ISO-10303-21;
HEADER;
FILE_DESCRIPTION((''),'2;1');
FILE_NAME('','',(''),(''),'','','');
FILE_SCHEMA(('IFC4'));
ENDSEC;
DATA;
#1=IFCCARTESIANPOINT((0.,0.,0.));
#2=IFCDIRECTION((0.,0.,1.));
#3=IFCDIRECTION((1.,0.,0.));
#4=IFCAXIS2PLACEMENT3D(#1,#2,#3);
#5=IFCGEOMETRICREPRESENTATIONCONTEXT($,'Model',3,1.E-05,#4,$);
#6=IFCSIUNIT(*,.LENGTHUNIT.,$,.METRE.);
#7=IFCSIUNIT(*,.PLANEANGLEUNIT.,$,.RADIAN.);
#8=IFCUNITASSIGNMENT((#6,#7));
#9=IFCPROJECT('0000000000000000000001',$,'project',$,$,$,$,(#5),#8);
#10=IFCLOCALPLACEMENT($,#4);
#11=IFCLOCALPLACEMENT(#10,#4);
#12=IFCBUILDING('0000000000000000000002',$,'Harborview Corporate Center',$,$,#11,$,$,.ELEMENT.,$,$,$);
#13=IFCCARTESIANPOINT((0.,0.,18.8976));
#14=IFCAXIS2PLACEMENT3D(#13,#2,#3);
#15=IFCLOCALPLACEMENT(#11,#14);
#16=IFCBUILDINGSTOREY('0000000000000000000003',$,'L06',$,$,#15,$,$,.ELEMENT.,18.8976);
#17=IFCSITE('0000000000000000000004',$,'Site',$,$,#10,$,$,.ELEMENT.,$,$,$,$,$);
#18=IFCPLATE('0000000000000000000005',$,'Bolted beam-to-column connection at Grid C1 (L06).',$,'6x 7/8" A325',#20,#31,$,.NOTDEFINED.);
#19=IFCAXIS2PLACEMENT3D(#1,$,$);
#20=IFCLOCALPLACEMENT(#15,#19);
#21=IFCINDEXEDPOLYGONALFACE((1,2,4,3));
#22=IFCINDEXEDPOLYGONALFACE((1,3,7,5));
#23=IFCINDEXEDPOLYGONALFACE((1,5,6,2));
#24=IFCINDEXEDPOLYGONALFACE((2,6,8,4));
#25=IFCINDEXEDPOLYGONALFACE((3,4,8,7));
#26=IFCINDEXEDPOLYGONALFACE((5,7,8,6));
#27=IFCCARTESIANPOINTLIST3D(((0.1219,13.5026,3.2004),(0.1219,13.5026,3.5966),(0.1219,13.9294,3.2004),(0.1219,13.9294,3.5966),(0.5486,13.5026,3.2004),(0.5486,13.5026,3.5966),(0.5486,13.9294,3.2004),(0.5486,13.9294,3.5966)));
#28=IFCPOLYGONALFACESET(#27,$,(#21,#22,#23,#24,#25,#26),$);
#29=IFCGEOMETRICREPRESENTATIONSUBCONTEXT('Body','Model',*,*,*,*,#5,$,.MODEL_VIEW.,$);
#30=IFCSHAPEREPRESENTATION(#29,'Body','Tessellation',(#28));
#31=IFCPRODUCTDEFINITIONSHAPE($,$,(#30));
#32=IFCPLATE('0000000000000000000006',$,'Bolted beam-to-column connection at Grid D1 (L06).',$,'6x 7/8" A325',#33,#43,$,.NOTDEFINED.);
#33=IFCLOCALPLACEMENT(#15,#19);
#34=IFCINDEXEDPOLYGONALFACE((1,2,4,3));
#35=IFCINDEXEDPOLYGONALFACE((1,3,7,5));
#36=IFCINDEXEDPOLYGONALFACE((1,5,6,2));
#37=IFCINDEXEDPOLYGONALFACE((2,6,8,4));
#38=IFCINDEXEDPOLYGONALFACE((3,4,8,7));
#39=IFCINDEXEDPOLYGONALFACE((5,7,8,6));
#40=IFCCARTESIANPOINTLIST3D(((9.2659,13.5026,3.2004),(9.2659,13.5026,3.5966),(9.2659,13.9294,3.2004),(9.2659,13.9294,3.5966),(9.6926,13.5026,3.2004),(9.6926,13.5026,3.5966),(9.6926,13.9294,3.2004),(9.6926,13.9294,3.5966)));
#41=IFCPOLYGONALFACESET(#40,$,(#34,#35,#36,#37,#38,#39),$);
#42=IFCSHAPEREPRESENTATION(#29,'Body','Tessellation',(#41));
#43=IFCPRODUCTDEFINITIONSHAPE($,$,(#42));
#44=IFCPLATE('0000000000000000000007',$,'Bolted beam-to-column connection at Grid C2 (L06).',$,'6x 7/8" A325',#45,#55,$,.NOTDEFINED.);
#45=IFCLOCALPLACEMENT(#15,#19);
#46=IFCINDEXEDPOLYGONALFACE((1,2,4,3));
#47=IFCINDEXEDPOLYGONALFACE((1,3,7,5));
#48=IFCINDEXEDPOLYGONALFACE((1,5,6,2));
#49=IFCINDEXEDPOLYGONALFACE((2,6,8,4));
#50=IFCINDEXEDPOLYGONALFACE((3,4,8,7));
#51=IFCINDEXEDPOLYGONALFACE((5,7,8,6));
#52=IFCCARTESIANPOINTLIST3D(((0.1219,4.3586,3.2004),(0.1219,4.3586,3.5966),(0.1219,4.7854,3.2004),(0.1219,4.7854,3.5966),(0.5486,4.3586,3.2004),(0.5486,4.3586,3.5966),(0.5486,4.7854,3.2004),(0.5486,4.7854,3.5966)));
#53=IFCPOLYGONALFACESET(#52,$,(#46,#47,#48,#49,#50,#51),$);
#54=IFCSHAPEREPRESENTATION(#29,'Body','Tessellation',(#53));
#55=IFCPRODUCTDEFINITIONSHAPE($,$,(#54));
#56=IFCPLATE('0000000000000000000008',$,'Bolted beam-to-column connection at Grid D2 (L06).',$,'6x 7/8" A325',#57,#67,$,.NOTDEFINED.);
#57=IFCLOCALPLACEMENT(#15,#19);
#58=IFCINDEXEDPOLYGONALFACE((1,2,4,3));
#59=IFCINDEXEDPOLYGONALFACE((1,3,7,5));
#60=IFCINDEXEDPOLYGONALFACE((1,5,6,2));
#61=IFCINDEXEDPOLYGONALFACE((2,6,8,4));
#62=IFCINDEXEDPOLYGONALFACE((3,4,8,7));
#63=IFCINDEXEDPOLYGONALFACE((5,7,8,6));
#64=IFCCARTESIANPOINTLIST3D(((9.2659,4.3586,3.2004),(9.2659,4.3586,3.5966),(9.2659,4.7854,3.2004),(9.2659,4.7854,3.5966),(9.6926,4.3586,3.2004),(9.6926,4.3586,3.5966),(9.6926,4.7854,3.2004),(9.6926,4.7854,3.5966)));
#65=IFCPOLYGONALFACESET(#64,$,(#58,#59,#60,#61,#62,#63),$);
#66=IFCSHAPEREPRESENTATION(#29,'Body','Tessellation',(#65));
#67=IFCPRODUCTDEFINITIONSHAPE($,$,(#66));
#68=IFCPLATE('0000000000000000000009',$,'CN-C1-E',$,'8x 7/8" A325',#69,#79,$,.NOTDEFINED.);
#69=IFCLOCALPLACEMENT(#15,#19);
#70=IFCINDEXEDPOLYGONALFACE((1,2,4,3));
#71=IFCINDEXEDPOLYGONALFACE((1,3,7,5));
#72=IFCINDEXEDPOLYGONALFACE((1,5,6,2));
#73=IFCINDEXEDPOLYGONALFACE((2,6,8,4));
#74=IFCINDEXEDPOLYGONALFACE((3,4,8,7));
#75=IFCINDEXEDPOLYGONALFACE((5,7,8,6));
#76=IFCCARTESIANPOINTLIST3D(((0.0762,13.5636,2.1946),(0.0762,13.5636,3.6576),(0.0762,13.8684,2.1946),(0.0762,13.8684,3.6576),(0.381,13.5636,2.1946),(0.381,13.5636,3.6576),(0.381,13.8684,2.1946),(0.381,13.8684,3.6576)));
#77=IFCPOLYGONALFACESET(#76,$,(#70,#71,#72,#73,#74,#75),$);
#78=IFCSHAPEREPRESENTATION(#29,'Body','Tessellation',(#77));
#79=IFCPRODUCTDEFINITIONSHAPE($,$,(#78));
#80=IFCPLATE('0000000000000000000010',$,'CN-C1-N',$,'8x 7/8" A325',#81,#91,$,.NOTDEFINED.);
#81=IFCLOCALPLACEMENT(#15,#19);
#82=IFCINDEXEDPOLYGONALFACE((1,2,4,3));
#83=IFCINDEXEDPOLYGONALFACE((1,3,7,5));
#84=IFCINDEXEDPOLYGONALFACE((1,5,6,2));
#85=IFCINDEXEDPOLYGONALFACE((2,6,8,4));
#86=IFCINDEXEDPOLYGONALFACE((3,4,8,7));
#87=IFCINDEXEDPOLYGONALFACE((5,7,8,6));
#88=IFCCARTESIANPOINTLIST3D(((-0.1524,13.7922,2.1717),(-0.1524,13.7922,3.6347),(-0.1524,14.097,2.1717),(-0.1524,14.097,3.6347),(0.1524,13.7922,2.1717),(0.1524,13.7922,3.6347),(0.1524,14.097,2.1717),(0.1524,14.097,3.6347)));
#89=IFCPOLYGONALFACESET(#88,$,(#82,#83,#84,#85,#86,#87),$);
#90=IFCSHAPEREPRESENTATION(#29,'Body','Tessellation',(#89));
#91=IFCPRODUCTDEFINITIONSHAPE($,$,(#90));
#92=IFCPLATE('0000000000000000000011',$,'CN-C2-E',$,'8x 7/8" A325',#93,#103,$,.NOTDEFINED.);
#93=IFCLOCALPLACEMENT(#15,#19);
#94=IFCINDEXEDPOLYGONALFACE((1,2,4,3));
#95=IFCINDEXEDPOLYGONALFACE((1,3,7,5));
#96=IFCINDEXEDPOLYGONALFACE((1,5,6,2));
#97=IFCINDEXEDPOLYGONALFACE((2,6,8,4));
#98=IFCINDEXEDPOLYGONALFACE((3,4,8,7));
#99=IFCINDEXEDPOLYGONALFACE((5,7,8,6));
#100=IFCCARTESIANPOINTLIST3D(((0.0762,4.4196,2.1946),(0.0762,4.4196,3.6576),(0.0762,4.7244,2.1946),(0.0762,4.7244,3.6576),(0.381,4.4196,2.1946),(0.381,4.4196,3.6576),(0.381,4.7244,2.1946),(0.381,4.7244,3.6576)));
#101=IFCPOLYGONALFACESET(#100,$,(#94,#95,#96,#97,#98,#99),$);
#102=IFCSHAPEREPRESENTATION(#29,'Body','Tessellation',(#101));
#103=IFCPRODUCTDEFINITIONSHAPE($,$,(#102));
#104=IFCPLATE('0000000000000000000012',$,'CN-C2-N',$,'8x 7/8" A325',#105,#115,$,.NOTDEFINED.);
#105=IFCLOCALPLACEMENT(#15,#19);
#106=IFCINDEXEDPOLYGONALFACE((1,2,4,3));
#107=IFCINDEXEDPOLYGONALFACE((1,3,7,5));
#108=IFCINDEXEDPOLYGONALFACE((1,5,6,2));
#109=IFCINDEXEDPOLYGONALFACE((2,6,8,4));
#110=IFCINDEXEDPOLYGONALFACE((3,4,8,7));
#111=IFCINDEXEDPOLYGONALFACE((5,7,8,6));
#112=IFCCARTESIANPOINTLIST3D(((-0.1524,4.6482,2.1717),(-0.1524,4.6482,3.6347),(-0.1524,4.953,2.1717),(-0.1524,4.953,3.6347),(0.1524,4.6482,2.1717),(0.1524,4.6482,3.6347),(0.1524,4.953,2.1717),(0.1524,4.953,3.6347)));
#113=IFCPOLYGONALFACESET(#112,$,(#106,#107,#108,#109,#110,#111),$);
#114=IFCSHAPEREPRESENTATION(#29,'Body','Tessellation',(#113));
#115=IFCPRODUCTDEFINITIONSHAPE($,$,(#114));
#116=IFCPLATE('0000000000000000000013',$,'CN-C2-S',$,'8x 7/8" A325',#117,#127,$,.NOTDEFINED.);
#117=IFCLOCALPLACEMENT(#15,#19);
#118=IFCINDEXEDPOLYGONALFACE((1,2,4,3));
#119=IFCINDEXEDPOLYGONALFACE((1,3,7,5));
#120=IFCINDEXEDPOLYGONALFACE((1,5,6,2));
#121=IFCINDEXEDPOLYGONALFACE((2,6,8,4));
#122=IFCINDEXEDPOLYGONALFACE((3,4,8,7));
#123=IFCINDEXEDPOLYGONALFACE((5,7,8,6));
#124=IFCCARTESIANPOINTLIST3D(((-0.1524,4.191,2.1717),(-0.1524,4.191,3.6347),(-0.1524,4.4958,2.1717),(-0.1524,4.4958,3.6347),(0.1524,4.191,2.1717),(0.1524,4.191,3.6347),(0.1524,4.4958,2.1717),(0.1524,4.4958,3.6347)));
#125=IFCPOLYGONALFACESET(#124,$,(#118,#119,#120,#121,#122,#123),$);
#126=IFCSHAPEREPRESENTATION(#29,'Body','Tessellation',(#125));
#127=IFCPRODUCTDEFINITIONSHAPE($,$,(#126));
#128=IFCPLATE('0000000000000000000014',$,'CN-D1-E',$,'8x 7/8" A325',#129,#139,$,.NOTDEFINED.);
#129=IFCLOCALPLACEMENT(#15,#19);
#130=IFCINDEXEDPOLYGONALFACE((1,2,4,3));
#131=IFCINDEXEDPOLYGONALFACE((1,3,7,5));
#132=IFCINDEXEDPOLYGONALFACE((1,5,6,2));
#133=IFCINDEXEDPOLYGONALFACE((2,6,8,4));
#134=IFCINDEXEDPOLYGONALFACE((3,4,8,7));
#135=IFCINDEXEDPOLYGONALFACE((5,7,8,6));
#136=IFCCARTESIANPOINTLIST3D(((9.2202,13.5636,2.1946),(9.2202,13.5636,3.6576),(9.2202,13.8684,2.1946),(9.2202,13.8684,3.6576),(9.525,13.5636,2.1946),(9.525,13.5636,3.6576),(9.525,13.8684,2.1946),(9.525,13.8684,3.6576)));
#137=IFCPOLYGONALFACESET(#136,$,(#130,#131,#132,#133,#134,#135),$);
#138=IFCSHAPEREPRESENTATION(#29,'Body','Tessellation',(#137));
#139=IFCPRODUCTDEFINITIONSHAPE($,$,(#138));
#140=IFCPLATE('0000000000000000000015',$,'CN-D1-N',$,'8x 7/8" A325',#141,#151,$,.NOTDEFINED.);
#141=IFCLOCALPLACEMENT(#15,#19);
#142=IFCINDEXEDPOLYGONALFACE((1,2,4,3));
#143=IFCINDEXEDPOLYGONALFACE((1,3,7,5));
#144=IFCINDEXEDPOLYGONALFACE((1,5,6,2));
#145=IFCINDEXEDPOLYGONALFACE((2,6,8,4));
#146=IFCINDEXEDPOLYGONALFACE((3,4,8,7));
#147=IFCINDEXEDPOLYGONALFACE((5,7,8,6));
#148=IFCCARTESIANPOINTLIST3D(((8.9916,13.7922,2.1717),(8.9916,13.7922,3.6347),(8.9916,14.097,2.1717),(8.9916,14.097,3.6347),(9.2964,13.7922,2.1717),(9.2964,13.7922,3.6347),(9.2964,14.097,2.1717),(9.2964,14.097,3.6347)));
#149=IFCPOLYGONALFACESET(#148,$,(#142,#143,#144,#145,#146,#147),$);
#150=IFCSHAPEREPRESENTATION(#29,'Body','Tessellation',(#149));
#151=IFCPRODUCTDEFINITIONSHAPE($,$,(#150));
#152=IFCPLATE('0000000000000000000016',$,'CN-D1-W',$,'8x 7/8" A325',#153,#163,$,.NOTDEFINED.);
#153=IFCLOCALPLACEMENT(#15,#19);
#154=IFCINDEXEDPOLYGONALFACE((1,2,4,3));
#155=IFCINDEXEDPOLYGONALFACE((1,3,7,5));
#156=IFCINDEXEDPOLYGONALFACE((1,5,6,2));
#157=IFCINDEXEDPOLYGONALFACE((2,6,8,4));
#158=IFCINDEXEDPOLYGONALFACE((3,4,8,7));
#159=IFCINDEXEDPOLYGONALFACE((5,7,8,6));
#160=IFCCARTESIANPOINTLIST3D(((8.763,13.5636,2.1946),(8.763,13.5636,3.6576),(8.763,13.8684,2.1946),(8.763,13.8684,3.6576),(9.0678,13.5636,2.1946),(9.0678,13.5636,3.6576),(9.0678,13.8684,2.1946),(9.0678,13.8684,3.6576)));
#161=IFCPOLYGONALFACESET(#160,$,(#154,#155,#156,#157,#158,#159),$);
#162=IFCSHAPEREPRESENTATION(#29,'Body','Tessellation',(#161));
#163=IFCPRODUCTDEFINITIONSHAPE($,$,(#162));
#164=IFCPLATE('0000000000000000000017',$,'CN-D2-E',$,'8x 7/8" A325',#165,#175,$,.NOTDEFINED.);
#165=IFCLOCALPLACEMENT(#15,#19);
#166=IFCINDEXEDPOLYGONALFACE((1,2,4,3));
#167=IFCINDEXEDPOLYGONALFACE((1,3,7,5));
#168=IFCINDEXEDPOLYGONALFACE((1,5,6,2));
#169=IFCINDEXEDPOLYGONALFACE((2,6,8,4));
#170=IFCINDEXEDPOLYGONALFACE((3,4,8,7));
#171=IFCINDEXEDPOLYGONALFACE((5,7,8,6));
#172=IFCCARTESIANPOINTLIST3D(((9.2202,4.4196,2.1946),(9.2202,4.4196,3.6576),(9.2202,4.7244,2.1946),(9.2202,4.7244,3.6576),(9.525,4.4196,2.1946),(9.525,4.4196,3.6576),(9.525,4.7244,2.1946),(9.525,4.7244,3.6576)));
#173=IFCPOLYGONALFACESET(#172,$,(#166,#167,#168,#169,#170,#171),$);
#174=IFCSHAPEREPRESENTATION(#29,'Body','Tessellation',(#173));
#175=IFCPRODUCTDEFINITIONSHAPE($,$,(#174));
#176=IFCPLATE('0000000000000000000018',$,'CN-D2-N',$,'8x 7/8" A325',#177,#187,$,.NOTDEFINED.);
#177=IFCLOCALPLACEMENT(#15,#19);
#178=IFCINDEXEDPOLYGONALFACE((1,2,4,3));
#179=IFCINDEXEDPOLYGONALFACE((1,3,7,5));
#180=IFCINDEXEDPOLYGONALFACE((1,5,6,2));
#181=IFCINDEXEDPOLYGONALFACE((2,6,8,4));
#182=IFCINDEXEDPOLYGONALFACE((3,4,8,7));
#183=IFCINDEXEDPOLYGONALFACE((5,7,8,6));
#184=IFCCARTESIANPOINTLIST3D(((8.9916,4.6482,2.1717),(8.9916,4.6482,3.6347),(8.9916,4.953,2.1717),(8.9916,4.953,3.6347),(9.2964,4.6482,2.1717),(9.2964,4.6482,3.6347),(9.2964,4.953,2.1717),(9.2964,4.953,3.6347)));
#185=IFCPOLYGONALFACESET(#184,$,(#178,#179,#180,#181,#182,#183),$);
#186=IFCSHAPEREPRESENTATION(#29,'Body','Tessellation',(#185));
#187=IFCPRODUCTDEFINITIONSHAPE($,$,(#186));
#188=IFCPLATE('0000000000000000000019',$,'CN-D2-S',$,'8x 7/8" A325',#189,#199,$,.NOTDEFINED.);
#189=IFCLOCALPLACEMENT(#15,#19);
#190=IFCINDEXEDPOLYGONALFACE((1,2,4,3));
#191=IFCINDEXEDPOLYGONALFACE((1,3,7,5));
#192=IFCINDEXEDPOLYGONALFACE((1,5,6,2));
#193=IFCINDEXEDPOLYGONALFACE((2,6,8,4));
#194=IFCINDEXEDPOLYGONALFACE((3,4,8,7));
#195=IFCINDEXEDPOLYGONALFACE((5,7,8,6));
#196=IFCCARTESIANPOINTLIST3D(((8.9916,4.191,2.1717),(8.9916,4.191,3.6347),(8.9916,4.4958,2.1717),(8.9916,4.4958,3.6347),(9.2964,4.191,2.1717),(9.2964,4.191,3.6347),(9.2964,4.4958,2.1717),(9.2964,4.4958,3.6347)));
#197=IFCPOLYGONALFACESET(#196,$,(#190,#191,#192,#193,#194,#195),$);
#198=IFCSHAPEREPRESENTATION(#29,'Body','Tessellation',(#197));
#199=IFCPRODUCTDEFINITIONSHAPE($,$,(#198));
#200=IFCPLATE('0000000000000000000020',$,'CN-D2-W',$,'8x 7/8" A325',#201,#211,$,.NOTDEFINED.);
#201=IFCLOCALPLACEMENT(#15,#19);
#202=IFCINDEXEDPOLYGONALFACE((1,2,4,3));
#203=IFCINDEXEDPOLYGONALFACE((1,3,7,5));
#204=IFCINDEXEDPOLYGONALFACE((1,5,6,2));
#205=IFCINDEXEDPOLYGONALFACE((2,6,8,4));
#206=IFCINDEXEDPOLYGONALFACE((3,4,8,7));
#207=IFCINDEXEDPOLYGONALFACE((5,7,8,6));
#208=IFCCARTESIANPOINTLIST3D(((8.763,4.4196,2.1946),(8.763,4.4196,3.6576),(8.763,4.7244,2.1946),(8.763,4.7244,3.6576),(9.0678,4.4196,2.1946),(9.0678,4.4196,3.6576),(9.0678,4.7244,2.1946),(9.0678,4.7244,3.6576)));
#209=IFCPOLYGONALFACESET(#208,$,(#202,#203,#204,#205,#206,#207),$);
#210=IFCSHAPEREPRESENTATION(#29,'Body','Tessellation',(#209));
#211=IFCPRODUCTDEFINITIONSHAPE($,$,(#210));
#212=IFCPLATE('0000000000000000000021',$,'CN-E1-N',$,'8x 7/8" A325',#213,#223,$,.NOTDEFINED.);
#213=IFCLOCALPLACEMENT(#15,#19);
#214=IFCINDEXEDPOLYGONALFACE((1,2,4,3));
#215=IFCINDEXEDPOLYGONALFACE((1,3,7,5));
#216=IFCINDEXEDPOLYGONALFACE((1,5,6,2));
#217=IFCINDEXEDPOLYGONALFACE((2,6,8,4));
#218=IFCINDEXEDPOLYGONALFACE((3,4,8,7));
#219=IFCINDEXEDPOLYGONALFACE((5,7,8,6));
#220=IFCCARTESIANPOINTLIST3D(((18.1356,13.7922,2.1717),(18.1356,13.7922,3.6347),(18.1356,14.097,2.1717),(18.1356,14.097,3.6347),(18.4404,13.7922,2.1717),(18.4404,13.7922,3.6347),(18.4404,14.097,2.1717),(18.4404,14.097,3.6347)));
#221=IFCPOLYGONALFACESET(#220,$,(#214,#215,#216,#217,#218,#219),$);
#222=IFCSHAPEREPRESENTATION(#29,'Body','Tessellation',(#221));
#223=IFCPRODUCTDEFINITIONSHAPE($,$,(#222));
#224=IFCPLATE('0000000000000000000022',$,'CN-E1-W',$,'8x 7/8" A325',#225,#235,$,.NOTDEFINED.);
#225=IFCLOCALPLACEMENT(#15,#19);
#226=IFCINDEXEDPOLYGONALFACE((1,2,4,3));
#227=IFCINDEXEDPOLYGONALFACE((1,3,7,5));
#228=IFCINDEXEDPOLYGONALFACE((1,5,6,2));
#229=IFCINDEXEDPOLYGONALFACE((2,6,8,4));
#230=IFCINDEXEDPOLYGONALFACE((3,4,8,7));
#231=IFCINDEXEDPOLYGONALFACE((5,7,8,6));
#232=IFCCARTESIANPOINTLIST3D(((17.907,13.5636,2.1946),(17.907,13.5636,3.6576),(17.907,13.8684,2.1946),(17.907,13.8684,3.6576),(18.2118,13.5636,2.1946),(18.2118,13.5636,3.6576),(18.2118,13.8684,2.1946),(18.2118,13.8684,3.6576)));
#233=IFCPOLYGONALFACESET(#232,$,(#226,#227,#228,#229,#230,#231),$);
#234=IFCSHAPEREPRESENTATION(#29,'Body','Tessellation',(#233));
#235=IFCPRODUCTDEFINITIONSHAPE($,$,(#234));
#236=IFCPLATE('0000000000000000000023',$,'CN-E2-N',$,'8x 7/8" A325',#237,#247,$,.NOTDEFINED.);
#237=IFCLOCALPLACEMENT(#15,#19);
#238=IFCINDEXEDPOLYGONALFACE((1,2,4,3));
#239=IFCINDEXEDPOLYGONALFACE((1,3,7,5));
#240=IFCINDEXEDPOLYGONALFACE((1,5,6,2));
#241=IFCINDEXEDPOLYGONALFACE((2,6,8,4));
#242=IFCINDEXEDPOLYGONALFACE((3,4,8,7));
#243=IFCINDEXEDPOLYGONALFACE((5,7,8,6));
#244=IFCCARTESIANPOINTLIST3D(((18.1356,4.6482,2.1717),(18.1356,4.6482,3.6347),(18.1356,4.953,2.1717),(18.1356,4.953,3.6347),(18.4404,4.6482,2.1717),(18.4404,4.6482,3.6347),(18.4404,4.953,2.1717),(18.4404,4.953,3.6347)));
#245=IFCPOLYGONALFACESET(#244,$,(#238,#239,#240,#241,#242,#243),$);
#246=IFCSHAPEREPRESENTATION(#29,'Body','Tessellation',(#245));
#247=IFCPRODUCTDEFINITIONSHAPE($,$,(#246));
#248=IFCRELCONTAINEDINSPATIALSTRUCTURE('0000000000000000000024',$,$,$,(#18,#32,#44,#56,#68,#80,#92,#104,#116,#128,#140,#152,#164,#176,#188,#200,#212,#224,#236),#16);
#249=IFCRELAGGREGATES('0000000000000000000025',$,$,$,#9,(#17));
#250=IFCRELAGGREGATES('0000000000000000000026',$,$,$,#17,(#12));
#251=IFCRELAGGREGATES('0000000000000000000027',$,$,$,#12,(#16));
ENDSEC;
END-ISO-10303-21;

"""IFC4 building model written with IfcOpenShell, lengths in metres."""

from ifc_helpers import new_model, si_unit, frame, origin_with_axes, place, context, subcontext, project, spatial, rectangle, extrude, element, save


model = new_model("IFC4")

# Units and contexts
model_context = context("Model", 3, precision=1e-05, world=origin_with_axes())
body_context = subcontext(model_context, "Body", "Model", "MODEL_VIEW")
ifc_project = project(units=[si_unit("LENGTHUNIT", "METRE"), si_unit("PLANEANGLEUNIT", "RADIAN")], contexts=[model_context])

# Site, building, storey
site_placement = place(None, origin_with_axes())
site = spatial("IfcSite", under=ifc_project, at=site_placement, Name="Site", CompositionType="ELEMENT")
building_placement = place(site_placement, origin_with_axes())
building = spatial("IfcBuilding", under=site, at=building_placement, Name="Harborview Corporate Center", CompositionType="ELEMENT")
storey_placement = place(building_placement, frame((0.0, 0.0, 18.8976), z_axis=(0.0, 0.0, 1.0), x_axis=(1.0, 0.0, 0.0)))
storey = spatial("IfcBuildingStorey", under=building, at=storey_placement, Name="L06", CompositionType="ELEMENT", Elevation=18.8976)

# Plates
plate_1_placement = place(storey_placement, frame((0.3353, 13.716, 3.2004), z_axis=(0.0, 0.0, 1.0), x_axis=(1.0, 0.0, 0.0)))
element("IfcPlate", 1, at=plate_1_placement, inside=storey, Name="Bolted beam-to-column connection at Grid C1 (L06).", ObjectType="6x 7/8\" A325", PredefinedType="NOTDEFINED", context=body_context, shape_type="SweptSolid", body=[
    extrude(rectangle(XDim=0.4267, YDim=0.4267), origin_with_axes(), (0.0, 0.0, 1.0), 0.3962),
])
plate_2_placement = place(storey_placement, frame((9.4793, 13.716, 3.2004), z_axis=(0.0, 0.0, 1.0), x_axis=(1.0, 0.0, 0.0)))
element("IfcPlate", 2, at=plate_2_placement, inside=storey, Name="Bolted beam-to-column connection at Grid D1 (L06).", ObjectType="6x 7/8\" A325", PredefinedType="NOTDEFINED", context=body_context, shape_type="SweptSolid", body=[
    extrude(rectangle(XDim=0.4267, YDim=0.4267), origin_with_axes(), (0.0, 0.0, 1.0), 0.3962),
])
plate_3_placement = place(storey_placement, frame((0.3353, 4.572, 3.2004), z_axis=(0.0, 0.0, 1.0), x_axis=(1.0, 0.0, 0.0)))
element("IfcPlate", 3, at=plate_3_placement, inside=storey, Name="Bolted beam-to-column connection at Grid C2 (L06).", ObjectType="6x 7/8\" A325", PredefinedType="NOTDEFINED", context=body_context, shape_type="SweptSolid", body=[
    extrude(rectangle(XDim=0.4267, YDim=0.4267), origin_with_axes(), (0.0, 0.0, 1.0), 0.3962),
])
plate_4_placement = place(storey_placement, frame((9.4793, 4.572, 3.2004), z_axis=(0.0, 0.0, 1.0), x_axis=(1.0, 0.0, 0.0)))
element("IfcPlate", 4, at=plate_4_placement, inside=storey, Name="Bolted beam-to-column connection at Grid D2 (L06).", ObjectType="6x 7/8\" A325", PredefinedType="NOTDEFINED", context=body_context, shape_type="SweptSolid", body=[
    extrude(rectangle(XDim=0.4267, YDim=0.4267), origin_with_axes(), (0.0, 0.0, 1.0), 0.3962),
])
for number, where, z_axis, x_axis, name in (
    (5, (0.2286, 13.716, 2.1946), (0.0, 0.0, 1.0), (1.0, 0.0, 0.0), "CN-C1-E"),
    (6, (0.0, 13.9446, 2.1717), (0.0, 0.0, 1.0), (1.0, 0.0, 0.0), "CN-C1-N"),
    (7, (0.2286, 4.572, 2.1946), (0.0, 0.0, 1.0), (1.0, 0.0, 0.0), "CN-C2-E"),
    (8, (0.0, 4.8006, 2.1717), (0.0, 0.0, 1.0), (1.0, 0.0, 0.0), "CN-C2-N"),
    (9, (0.0, 4.3434, 2.1717), (0.0, 0.0, 1.0), (1.0, 0.0, 0.0), "CN-C2-S"),
):
    element("IfcPlate", number, at=place(storey_placement, frame(where, z_axis=z_axis, x_axis=x_axis)), inside=storey, Name=name, ObjectType="8x 7/8\" A325", PredefinedType="NOTDEFINED", context=body_context, shape_type="SweptSolid", body=[
        extrude(rectangle(XDim=0.3048, YDim=0.3048), origin_with_axes(), (0.0, 0.0, 1.0), 1.463),
    ])
for number, where, z_axis, x_axis, name in (
    (10, (9.3726, 13.716, 2.1946), (0.0, 0.0, 1.0), (1.0, 0.0, 0.0), "CN-D1-E"),
    (11, (9.144, 13.9446, 2.1717), (0.0, 0.0, 1.0), (1.0, 0.0, 0.0), "CN-D1-N"),
    (12, (8.9154, 13.716, 2.1946), (0.0, 0.0, 1.0), (1.0, 0.0, 0.0), "CN-D1-W"),
    (13, (9.3726, 4.572, 2.1946), (0.0, 0.0, 1.0), (1.0, 0.0, 0.0), "CN-D2-E"),
    (14, (9.144, 4.8006, 2.1717), (0.0, 0.0, 1.0), (1.0, 0.0, 0.0), "CN-D2-N"),
    (15, (9.144, 4.3434, 2.1717), (0.0, 0.0, 1.0), (1.0, 0.0, 0.0), "CN-D2-S"),
    (16, (8.9154, 4.572, 2.1946), (0.0, 0.0, 1.0), (1.0, 0.0, 0.0), "CN-D2-W"),
    (17, (18.288, 13.9446, 2.1717), (0.0, 0.0, 1.0), (1.0, 0.0, 0.0), "CN-E1-N"),
    (18, (18.0594, 13.716, 2.1946), (0.0, 0.0, 1.0), (1.0, 0.0, 0.0), "CN-E1-W"),
    (19, (18.288, 4.8006, 2.1717), (0.0, 0.0, 1.0), (1.0, 0.0, 0.0), "CN-E2-N"),
):
    element("IfcPlate", number, at=place(storey_placement, frame(where, z_axis=z_axis, x_axis=x_axis)), inside=storey, Name=name, ObjectType="8x 7/8\" A325", PredefinedType="NOTDEFINED", context=body_context, shape_type="SweptSolid", body=[
        extrude(rectangle(XDim=0.3048, YDim=0.3048), origin_with_axes(), (0.0, 0.0, 1.0), 1.463),
    ])

save(model, "model.ifc")
